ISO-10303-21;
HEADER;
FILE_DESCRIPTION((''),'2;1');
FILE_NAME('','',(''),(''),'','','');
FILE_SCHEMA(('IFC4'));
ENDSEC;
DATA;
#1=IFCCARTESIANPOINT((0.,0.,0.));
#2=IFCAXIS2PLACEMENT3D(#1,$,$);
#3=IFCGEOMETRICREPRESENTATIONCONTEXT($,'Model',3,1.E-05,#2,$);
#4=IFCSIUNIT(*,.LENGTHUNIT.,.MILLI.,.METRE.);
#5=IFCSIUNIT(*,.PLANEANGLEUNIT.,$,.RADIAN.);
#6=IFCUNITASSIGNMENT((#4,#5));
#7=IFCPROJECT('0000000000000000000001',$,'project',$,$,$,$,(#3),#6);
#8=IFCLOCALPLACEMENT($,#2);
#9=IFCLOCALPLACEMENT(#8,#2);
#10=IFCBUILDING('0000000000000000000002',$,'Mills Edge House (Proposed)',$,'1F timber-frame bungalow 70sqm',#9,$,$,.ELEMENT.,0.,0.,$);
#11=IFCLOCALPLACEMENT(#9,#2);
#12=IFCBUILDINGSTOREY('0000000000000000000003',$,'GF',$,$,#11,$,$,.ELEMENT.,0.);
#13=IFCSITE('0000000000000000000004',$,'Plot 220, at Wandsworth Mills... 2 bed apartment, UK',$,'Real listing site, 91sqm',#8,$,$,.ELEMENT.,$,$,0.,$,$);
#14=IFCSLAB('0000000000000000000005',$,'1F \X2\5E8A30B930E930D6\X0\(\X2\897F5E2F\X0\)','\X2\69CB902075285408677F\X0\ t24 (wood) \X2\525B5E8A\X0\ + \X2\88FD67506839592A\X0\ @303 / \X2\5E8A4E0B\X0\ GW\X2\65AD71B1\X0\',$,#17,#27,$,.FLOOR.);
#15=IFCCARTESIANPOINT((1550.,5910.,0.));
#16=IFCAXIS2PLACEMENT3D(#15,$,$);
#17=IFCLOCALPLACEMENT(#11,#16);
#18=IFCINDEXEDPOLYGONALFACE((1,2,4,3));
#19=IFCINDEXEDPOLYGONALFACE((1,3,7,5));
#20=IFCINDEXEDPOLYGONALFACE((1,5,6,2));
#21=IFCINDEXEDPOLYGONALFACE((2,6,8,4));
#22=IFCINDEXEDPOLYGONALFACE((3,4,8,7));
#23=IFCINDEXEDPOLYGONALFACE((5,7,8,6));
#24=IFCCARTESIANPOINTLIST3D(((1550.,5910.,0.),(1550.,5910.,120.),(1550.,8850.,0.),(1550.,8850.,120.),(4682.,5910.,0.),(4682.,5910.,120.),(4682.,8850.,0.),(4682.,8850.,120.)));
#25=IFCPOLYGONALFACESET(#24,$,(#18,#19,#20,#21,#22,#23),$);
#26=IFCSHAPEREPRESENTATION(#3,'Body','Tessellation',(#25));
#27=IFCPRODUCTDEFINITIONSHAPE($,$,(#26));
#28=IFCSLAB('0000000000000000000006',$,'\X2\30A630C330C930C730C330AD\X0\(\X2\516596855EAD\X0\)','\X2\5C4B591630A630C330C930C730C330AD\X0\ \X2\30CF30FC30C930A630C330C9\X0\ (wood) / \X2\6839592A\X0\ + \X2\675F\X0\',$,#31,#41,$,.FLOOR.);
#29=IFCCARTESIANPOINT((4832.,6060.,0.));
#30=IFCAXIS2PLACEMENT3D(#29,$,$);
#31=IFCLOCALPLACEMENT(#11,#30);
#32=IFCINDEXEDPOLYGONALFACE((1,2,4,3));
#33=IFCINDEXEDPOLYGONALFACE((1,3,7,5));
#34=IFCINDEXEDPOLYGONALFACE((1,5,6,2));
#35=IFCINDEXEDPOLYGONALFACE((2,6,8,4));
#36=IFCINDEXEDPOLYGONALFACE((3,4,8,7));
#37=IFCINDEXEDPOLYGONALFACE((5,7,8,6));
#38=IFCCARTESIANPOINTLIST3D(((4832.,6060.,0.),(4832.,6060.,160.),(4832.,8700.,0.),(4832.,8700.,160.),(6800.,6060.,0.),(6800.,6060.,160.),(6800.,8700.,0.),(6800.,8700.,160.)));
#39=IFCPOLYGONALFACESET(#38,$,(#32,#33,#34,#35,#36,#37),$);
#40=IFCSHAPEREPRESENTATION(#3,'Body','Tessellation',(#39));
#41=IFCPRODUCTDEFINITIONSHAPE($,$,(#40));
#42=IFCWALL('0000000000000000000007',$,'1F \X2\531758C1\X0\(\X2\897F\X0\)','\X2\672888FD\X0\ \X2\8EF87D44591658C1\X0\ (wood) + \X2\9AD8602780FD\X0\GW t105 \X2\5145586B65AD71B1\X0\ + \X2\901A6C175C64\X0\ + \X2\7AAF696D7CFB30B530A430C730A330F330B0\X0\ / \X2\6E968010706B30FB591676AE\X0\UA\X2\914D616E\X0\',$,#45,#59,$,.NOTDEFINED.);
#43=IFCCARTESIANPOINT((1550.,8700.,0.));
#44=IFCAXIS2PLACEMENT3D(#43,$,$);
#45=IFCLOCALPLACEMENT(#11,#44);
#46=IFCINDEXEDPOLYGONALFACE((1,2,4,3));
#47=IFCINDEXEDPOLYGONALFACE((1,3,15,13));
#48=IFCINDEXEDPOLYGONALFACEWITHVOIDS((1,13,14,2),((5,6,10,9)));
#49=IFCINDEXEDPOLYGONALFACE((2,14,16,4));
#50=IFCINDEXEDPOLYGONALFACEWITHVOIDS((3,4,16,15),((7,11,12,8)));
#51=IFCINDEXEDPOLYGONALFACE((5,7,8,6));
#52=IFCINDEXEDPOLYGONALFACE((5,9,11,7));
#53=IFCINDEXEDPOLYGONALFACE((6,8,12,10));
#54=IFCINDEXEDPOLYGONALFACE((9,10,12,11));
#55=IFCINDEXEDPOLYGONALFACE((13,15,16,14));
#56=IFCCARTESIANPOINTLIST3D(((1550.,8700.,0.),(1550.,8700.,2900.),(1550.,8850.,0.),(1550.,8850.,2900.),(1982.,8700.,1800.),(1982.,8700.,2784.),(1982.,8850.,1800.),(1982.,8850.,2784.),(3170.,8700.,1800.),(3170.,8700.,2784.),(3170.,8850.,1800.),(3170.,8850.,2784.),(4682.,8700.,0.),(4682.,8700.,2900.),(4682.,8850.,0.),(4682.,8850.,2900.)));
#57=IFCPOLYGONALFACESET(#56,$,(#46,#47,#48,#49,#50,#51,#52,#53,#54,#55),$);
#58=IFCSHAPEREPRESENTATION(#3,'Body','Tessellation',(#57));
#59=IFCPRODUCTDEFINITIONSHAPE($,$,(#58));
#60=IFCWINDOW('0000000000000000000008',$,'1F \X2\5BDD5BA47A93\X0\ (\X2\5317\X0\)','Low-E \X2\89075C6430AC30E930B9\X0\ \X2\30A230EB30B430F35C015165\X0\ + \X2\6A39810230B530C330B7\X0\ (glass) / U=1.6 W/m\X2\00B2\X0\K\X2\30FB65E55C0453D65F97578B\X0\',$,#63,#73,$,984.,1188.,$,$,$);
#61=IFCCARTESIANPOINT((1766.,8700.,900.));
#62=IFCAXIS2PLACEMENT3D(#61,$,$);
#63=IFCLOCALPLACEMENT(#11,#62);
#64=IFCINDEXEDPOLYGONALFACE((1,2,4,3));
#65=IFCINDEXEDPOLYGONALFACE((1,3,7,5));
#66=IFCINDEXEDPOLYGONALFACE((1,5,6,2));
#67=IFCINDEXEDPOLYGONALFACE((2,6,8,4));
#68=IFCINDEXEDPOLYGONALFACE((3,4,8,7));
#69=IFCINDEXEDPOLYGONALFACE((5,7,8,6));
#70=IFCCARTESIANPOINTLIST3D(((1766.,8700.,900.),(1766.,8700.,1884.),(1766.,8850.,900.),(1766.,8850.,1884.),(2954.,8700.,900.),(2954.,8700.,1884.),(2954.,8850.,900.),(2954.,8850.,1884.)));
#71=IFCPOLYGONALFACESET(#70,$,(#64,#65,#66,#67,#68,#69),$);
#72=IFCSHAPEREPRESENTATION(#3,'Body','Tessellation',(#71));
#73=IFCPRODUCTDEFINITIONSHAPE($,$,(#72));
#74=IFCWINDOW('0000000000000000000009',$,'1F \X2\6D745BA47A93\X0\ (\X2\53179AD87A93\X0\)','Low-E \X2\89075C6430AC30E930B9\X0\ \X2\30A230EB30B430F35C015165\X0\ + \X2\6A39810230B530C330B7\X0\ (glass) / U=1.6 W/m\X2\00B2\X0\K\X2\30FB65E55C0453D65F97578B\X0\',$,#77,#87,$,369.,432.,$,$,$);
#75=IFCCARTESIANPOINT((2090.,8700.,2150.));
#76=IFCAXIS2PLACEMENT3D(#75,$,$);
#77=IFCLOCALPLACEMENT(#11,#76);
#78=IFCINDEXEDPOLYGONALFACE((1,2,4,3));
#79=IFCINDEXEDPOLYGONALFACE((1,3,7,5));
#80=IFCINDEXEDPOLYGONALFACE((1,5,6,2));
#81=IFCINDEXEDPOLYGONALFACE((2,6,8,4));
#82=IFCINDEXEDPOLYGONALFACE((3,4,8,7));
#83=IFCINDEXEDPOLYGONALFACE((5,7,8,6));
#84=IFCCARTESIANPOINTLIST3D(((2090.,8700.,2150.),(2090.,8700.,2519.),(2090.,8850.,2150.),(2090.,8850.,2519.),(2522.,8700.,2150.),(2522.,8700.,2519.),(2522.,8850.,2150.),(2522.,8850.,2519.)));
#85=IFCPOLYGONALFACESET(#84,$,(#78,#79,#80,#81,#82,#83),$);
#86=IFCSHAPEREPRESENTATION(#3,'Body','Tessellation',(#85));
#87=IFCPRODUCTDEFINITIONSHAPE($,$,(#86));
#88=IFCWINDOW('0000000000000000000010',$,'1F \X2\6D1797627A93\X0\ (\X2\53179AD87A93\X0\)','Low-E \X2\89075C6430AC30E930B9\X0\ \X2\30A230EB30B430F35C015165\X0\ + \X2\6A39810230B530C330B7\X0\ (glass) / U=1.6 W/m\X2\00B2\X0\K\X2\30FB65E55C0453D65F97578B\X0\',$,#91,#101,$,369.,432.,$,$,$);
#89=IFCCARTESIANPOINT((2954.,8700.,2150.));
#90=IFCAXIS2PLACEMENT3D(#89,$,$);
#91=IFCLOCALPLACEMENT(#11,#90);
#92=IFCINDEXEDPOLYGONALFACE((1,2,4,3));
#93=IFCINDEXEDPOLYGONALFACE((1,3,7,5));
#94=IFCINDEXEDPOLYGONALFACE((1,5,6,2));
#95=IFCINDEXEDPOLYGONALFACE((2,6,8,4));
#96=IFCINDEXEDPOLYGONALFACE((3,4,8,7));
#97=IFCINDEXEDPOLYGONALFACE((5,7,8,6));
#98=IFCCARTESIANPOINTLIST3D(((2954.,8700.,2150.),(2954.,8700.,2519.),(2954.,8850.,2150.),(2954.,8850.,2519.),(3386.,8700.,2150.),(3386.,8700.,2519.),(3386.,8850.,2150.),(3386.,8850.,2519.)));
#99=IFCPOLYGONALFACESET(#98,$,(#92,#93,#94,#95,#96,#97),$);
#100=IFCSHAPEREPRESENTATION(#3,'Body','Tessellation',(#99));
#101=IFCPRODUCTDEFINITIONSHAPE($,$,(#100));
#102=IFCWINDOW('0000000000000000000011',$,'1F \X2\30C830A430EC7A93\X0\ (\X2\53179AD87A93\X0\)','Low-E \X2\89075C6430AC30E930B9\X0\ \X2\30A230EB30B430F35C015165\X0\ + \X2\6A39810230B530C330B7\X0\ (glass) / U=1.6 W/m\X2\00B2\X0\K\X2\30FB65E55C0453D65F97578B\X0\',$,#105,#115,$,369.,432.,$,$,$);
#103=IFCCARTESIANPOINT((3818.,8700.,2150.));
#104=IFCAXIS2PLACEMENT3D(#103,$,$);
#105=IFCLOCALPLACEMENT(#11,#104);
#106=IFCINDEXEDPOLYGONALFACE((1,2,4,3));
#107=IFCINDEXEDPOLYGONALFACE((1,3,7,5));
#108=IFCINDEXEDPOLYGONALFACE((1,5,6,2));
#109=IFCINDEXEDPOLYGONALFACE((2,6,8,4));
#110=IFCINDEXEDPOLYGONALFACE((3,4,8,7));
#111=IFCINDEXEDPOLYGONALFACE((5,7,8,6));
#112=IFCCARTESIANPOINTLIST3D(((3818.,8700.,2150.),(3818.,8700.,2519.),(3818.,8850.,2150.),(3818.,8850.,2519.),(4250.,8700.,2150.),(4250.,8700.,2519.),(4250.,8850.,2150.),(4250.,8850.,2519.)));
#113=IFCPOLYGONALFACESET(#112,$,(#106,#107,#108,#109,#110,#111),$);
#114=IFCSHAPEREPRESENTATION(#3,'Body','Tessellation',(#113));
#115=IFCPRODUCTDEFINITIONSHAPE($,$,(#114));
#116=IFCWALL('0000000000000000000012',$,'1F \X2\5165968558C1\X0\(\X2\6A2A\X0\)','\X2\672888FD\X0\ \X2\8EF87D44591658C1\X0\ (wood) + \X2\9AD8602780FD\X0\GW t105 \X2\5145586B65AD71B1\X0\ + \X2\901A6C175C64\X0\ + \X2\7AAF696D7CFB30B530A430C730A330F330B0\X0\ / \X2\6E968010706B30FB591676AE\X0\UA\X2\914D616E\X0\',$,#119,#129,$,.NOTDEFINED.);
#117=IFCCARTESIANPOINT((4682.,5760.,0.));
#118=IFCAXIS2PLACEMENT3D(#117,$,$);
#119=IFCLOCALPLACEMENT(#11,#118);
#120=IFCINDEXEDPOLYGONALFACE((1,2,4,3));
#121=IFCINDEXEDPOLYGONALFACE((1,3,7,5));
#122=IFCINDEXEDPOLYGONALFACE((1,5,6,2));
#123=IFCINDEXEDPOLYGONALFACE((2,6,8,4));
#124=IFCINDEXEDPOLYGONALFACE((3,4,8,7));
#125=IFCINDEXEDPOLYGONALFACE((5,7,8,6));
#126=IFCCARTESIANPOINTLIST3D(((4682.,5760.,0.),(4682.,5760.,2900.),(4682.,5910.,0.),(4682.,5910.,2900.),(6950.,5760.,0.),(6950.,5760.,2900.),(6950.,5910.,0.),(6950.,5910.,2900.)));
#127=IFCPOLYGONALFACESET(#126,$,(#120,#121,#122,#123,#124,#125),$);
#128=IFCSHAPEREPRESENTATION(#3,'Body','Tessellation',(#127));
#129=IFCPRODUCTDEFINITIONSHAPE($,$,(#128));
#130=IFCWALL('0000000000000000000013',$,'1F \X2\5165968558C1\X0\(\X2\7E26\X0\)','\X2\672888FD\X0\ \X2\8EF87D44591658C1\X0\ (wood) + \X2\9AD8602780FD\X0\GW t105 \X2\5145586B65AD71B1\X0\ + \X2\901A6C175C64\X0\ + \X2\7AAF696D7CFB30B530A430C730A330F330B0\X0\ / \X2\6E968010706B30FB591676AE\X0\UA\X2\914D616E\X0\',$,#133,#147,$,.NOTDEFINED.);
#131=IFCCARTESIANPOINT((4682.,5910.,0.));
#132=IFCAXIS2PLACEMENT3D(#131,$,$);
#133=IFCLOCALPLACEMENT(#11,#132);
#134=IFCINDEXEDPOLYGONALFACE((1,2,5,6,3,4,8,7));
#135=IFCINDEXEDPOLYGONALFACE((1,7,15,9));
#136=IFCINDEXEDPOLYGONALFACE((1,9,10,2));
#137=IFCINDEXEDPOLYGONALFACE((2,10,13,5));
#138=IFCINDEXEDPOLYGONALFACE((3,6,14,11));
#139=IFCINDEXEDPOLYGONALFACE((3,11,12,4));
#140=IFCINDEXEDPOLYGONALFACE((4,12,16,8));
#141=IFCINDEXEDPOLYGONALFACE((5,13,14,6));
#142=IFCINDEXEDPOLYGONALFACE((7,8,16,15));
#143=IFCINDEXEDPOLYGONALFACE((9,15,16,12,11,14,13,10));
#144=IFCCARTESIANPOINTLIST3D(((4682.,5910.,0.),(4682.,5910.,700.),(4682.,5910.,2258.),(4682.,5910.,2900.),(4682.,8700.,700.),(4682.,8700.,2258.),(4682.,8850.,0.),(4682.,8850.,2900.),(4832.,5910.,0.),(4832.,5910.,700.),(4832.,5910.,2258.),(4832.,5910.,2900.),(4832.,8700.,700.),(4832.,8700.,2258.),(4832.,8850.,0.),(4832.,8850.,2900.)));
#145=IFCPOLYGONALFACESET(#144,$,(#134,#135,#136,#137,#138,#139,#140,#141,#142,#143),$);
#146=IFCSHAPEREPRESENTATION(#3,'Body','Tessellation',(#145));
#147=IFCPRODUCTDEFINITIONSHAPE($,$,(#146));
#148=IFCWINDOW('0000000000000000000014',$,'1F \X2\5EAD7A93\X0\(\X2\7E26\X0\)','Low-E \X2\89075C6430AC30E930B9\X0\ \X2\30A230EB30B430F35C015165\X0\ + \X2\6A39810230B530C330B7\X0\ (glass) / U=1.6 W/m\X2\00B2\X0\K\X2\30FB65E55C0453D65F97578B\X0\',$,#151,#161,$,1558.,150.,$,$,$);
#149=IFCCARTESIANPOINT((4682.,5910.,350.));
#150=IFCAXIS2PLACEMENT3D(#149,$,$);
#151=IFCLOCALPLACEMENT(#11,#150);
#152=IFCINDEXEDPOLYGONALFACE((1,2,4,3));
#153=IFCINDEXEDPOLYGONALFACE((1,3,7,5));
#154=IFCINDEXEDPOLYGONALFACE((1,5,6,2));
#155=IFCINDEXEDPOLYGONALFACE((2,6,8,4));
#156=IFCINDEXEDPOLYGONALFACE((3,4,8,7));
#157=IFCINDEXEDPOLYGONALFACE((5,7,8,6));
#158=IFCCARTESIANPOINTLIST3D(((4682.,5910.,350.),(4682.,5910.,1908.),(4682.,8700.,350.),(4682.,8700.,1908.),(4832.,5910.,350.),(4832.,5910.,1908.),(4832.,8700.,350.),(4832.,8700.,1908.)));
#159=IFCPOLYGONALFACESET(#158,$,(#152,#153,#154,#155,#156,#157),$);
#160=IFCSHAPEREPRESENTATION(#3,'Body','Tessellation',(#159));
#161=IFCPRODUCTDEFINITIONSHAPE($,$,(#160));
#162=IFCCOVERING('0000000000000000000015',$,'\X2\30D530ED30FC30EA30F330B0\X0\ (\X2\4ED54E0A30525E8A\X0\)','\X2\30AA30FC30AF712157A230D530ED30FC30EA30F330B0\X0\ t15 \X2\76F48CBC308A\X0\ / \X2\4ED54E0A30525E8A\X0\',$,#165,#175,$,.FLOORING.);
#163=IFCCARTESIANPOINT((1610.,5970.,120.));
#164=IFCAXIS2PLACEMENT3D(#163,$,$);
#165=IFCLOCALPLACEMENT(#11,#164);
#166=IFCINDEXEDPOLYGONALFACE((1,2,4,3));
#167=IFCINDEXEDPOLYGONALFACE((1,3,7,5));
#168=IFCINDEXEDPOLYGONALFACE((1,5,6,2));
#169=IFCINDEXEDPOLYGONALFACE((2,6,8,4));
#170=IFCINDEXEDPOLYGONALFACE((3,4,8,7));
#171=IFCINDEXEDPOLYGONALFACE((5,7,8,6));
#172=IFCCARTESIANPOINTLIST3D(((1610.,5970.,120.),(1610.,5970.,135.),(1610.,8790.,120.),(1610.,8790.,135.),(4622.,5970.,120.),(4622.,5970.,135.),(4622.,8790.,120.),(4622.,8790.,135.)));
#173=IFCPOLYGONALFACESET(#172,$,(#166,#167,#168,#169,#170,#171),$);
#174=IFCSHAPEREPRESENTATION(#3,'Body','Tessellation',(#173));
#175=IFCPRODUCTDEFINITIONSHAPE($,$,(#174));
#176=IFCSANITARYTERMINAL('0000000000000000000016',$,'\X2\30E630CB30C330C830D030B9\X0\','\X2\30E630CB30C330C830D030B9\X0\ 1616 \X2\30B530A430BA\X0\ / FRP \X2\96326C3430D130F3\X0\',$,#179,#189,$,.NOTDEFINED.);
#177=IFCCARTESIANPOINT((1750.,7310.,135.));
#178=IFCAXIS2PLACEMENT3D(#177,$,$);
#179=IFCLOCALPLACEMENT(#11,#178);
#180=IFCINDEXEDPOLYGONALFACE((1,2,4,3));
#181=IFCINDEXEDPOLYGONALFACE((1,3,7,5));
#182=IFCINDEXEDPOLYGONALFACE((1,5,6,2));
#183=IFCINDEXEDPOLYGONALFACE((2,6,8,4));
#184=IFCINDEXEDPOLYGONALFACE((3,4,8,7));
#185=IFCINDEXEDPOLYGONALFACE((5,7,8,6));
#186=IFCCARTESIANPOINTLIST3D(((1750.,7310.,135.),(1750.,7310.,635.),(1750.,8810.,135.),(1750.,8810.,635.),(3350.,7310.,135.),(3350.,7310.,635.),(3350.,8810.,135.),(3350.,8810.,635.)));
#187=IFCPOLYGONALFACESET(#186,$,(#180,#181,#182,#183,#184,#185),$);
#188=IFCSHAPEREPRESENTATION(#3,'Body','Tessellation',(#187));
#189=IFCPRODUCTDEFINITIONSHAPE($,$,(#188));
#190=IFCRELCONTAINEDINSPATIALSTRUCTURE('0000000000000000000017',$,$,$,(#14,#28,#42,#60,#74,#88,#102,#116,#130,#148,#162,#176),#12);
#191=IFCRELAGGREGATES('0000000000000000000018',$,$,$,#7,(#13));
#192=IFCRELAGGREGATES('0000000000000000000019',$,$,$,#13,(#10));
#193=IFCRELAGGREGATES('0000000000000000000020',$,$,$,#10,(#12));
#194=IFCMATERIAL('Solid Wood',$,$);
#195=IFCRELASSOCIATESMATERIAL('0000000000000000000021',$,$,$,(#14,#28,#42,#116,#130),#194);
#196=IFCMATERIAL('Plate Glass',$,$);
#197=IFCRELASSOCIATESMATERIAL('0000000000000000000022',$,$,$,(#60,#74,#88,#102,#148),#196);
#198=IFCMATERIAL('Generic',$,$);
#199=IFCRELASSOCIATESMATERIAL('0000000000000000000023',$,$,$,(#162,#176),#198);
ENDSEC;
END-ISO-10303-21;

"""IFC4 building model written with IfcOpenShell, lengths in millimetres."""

from ifc_helpers import new_model, si_unit, frame, frame_2d, origin, place, context, project, spatial, rectangle, extrude, material, element, fill, save


model = new_model("IFC4")

# Units and contexts
model_context = context("Model", 3, precision=1e-05, world=origin())
ifc_project = project(units=[si_unit("LENGTHUNIT", "METRE", prefix="MILLI"), si_unit("PLANEANGLEUNIT", "RADIAN")], contexts=[model_context])

# Site, building, storey
site_placement = place(None, origin())
site = spatial("IfcSite", under=ifc_project, at=site_placement, Name="Plot 220, at Wandsworth Mills... 2 bed apartment, UK", ObjectType="Real listing site, 91sqm", CompositionType="ELEMENT", RefElevation=0.0)
building_placement = place(site_placement, origin())
building = spatial("IfcBuilding", under=site, at=building_placement, Name="Mills Edge House (Proposed)", ObjectType="1F timber-frame bungalow 70sqm", CompositionType="ELEMENT", ElevationOfRefHeight=0.0, ElevationOfTerrain=0.0)
storey_placement = place(building_placement, origin())
storey = spatial("IfcBuildingStorey", under=building, at=storey_placement, Name="GF", CompositionType="ELEMENT", Elevation=0.0)

# Slabs
ifc_material_1 = material(Name="Solid Wood")
slab_1_placement = place(storey_placement, frame((1550.0, 5910.0, 0.0)))
element("IfcSlab", 1, at=slab_1_placement, inside=storey, material=ifc_material_1, Name="1F 床スラブ(西帯)", Description="構造用合板 t24 (wood) 剛床 + 製材根太 @303 / 床下 GW断熱", PredefinedType="FLOOR", context=model_context, shape_type="SweptSolid", body=[
    extrude(rectangle(XDim=3132.0, YDim=2940.0, at=frame_2d((1566.0, 1470.0))), frame((1550.0, 5910.0, 0.0)), (0.0, 0.0, 1.0), 120.0),
])
slab_2_placement = place(storey_placement, frame((4832.0, 6060.0, 0.0)))
element("IfcSlab", 2, at=slab_2_placement, inside=storey, material=ifc_material_1, Name="ウッドデッキ(入隅庭)", Description="屋外ウッドデッキ ハードウッド (wood) / 根太 + 束", PredefinedType="FLOOR", context=model_context, shape_type="SweptSolid", body=[
    extrude(rectangle(XDim=1968.0, YDim=2640.0, at=frame_2d((984.0, 1320.0))), frame((4832.0, 6060.0, 0.0)), (0.0, 0.0, 1.0), 160.0),
])

# Wall, openings, windows
wall_1_placement = place(storey_placement, frame((1550.0, 8700.0, 0.0)))
wall_1 = element("IfcWall", 3, at=wall_1_placement, inside=storey, material=ifc_material_1, Name="1F 北壁(西)", Description="木製 軸組外壁 (wood) + 高性能GW t105 充填断熱 + 通気層 + 窯業系サイディング / 準耐火・外皮UA配慮", PredefinedType="NOTDEFINED", context=model_context, shape_type="SweptSolid", body=[
    extrude(rectangle(XDim=3132.0, YDim=150.0, at=frame_2d((1566.0, 75.0))), frame((1550.0, 8700.0, 0.0)), (0.0, 0.0, 1.0), 2900.0),
])
opening_1_placement = place(storey_placement, frame((1766.0, 8700.0, 900.0)))
opening_1 = element("IfcOpeningElement", 4, at=opening_1_placement, cuts=wall_1, PredefinedType="NOTDEFINED", context=model_context, shape_type="SweptSolid", body=[
    extrude(rectangle(XDim=1188.0, YDim=150.0, at=frame_2d((594.0, 75.0))), frame((1766.0, 8700.0, 900.0)), (0.0, 0.0, 1.0), 984.0),
])
opening_2_placement = place(storey_placement, frame((2090.0, 8700.0, 2150.0)))
opening_2 = element("IfcOpeningElement", 5, at=opening_2_placement, cuts=wall_1, PredefinedType="NOTDEFINED", context=model_context, shape_type="SweptSolid", body=[
    extrude(rectangle(XDim=432.0, YDim=150.0, at=frame_2d((216.0, 75.0))), frame((2090.0, 8700.0, 2150.0)), (0.0, 0.0, 1.0), 369.0),
])
opening_3_placement = place(storey_placement, frame((2954.0, 8700.0, 2150.0)))
opening_3 = element("IfcOpeningElement", 6, at=opening_3_placement, cuts=wall_1, PredefinedType="NOTDEFINED", context=model_context, shape_type="SweptSolid", body=[
    extrude(rectangle(XDim=432.0, YDim=150.0, at=frame_2d((216.0, 75.0))), frame((2954.0, 8700.0, 2150.0)), (0.0, 0.0, 1.0), 369.0),
])
opening_4_placement = place(storey_placement, frame((3818.0, 8700.0, 2150.0)))
opening_4 = element("IfcOpeningElement", 7, at=opening_4_placement, cuts=wall_1, PredefinedType="NOTDEFINED", context=model_context, shape_type="SweptSolid", body=[
    extrude(rectangle(XDim=432.0, YDim=150.0, at=frame_2d((216.0, 75.0))), frame((3818.0, 8700.0, 2150.0)), (0.0, 0.0, 1.0), 369.0),
])
ifc_material_2 = material(Name="Plate Glass")
window_1_placement = place(storey_placement, frame((1766.0, 8700.0, 900.0)))
window_1 = element("IfcWindow", 8, at=window_1_placement, inside=storey, material=ifc_material_2, Name="1F 寝室窓 (北)", Description="Low-E 複層ガラス アルゴン封入 + 樹脂サッシ (glass) / U=1.6 W/m²K・日射取得型", OverallHeight=984.0, OverallWidth=1188.0, context=model_context, shape_type="SweptSolid", body=[
    extrude(rectangle(XDim=1188.0, YDim=150.0, at=frame_2d((594.0, 75.0))), frame((1766.0, 8700.0, 900.0)), (0.0, 0.0, 1.0), 984.0),
])
fill(opening_1, window_1)
window_2_placement = place(storey_placement, frame((2090.0, 8700.0, 2150.0)))
window_2 = element("IfcWindow", 9, at=window_2_placement, inside=storey, material=ifc_material_2, Name="1F 浴室窓 (北高窓)", Description="Low-E 複層ガラス アルゴン封入 + 樹脂サッシ (glass) / U=1.6 W/m²K・日射取得型", OverallHeight=369.0, OverallWidth=432.0, context=model_context, shape_type="SweptSolid", body=[
    extrude(rectangle(XDim=432.0, YDim=150.0, at=frame_2d((216.0, 75.0))), frame((2090.0, 8700.0, 2150.0)), (0.0, 0.0, 1.0), 369.0),
])
fill(opening_2, window_2)
window_3_placement = place(storey_placement, frame((2954.0, 8700.0, 2150.0)))
window_3 = element("IfcWindow", 10, at=window_3_placement, inside=storey, material=ifc_material_2, Name="1F 洗面窓 (北高窓)", Description="Low-E 複層ガラス アルゴン封入 + 樹脂サッシ (glass) / U=1.6 W/m²K・日射取得型", OverallHeight=369.0, OverallWidth=432.0, context=model_context, shape_type="SweptSolid", body=[
    extrude(rectangle(XDim=432.0, YDim=150.0, at=frame_2d((216.0, 75.0))), frame((2954.0, 8700.0, 2150.0)), (0.0, 0.0, 1.0), 369.0),
])
fill(opening_3, window_3)
window_4_placement = place(storey_placement, frame((3818.0, 8700.0, 2150.0)))
window_4 = element("IfcWindow", 11, at=window_4_placement, inside=storey, material=ifc_material_2, Name="1F トイレ窓 (北高窓)", Description="Low-E 複層ガラス アルゴン封入 + 樹脂サッシ (glass) / U=1.6 W/m²K・日射取得型", OverallHeight=369.0, OverallWidth=432.0, context=model_context, shape_type="SweptSolid", body=[
    extrude(rectangle(XDim=432.0, YDim=150.0, at=frame_2d((216.0, 75.0))), frame((3818.0, 8700.0, 2150.0)), (0.0, 0.0, 1.0), 369.0),
])
fill(opening_4, window_4)

# Wall
wall_2_placement = place(storey_placement, frame((4682.0, 5760.0, 0.0)))
element("IfcWall", 12, at=wall_2_placement, inside=storey, material=ifc_material_1, Name="1F 入隅壁(横)", Description="木製 軸組外壁 (wood) + 高性能GW t105 充填断熱 + 通気層 + 窯業系サイディング / 準耐火・外皮UA配慮", PredefinedType="NOTDEFINED", context=model_context, shape_type="SweptSolid", body=[
    extrude(rectangle(XDim=2268.0, YDim=150.0, at=frame_2d((1134.0, 75.0))), frame((4682.0, 5760.0, 0.0)), (0.0, 0.0, 1.0), 2900.0),
])

# Wall, opening, window
wall_3_placement = place(storey_placement, frame((4682.0, 5910.0, 0.0)))
wall_3 = element("IfcWall", 13, at=wall_3_placement, inside=storey, material=ifc_material_1, Name="1F 入隅壁(縦)", Description="木製 軸組外壁 (wood) + 高性能GW t105 充填断熱 + 通気層 + 窯業系サイディング / 準耐火・外皮UA配慮", PredefinedType="NOTDEFINED", context=model_context, shape_type="SweptSolid", body=[
    extrude(rectangle(XDim=150.0, YDim=2940.0, at=frame_2d((75.0, 1470.0))), frame((4682.0, 5910.0, 0.0)), (0.0, 0.0, 1.0), 2900.0),
])
opening_5_placement = place(storey_placement, frame((4682.0, 5910.0, 350.0)))
opening_5 = element("IfcOpeningElement", 14, at=opening_5_placement, cuts=wall_3, PredefinedType="NOTDEFINED", context=model_context, shape_type="SweptSolid", body=[
    extrude(rectangle(XDim=150.0, YDim=2790.0, at=frame_2d((75.0, 1395.0))), frame((4682.0, 5910.0, 350.0)), (0.0, 0.0, 1.0), 1558.0),
])
window_5_placement = place(storey_placement, frame((4682.0, 5910.0, 350.0)))
window_5 = element("IfcWindow", 15, at=window_5_placement, inside=storey, material=ifc_material_2, Name="1F 庭窓(縦)", Description="Low-E 複層ガラス アルゴン封入 + 樹脂サッシ (glass) / U=1.6 W/m²K・日射取得型", OverallHeight=1558.0, OverallWidth=150.0, context=model_context, shape_type="SweptSolid", body=[
    extrude(rectangle(XDim=150.0, YDim=2790.0, at=frame_2d((75.0, 1395.0))), frame((4682.0, 5910.0, 350.0)), (0.0, 0.0, 1.0), 1558.0),
])
fill(opening_5, window_5)

# Covering
ifc_material_3 = material(Name="Generic")
covering_placement = place(storey_placement, frame((1610.0, 5970.0, 120.0)))
element("IfcCovering", 16, at=covering_placement, inside=storey, material=ifc_material_3, Name="フローリング (仕上げ床)", Description="オーク無垢フローリング t15 直貼り / 仕上げ床", PredefinedType="FLOORING", context=model_context, shape_type="SweptSolid", body=[
    extrude(rectangle(XDim=3012.0, YDim=2820.0, at=frame_2d((1506.0, 1410.0))), frame((1610.0, 5970.0, 120.0)), (0.0, 0.0, 1.0), 15.0),
])

# Sanitary terminal
sanitary_terminal_1_placement = place(storey_placement, frame((1750.0, 7310.0, 135.0)))
element("IfcSanitaryTerminal", 17, at=sanitary_terminal_1_placement, inside=storey, material=ifc_material_3, Name="ユニットバス", Description="ユニットバス 1616 サイズ / FRP 防水パン", PredefinedType="NOTDEFINED", context=model_context, shape_type="SweptSolid", body=[
    extrude(rectangle(XDim=1600.0, YDim=1500.0, at=frame_2d((800.0, 750.0))), frame((1750.0, 7310.0, 135.0)), (0.0, 0.0, 1.0), 500.0),
])

save(model, "model.ifc")
